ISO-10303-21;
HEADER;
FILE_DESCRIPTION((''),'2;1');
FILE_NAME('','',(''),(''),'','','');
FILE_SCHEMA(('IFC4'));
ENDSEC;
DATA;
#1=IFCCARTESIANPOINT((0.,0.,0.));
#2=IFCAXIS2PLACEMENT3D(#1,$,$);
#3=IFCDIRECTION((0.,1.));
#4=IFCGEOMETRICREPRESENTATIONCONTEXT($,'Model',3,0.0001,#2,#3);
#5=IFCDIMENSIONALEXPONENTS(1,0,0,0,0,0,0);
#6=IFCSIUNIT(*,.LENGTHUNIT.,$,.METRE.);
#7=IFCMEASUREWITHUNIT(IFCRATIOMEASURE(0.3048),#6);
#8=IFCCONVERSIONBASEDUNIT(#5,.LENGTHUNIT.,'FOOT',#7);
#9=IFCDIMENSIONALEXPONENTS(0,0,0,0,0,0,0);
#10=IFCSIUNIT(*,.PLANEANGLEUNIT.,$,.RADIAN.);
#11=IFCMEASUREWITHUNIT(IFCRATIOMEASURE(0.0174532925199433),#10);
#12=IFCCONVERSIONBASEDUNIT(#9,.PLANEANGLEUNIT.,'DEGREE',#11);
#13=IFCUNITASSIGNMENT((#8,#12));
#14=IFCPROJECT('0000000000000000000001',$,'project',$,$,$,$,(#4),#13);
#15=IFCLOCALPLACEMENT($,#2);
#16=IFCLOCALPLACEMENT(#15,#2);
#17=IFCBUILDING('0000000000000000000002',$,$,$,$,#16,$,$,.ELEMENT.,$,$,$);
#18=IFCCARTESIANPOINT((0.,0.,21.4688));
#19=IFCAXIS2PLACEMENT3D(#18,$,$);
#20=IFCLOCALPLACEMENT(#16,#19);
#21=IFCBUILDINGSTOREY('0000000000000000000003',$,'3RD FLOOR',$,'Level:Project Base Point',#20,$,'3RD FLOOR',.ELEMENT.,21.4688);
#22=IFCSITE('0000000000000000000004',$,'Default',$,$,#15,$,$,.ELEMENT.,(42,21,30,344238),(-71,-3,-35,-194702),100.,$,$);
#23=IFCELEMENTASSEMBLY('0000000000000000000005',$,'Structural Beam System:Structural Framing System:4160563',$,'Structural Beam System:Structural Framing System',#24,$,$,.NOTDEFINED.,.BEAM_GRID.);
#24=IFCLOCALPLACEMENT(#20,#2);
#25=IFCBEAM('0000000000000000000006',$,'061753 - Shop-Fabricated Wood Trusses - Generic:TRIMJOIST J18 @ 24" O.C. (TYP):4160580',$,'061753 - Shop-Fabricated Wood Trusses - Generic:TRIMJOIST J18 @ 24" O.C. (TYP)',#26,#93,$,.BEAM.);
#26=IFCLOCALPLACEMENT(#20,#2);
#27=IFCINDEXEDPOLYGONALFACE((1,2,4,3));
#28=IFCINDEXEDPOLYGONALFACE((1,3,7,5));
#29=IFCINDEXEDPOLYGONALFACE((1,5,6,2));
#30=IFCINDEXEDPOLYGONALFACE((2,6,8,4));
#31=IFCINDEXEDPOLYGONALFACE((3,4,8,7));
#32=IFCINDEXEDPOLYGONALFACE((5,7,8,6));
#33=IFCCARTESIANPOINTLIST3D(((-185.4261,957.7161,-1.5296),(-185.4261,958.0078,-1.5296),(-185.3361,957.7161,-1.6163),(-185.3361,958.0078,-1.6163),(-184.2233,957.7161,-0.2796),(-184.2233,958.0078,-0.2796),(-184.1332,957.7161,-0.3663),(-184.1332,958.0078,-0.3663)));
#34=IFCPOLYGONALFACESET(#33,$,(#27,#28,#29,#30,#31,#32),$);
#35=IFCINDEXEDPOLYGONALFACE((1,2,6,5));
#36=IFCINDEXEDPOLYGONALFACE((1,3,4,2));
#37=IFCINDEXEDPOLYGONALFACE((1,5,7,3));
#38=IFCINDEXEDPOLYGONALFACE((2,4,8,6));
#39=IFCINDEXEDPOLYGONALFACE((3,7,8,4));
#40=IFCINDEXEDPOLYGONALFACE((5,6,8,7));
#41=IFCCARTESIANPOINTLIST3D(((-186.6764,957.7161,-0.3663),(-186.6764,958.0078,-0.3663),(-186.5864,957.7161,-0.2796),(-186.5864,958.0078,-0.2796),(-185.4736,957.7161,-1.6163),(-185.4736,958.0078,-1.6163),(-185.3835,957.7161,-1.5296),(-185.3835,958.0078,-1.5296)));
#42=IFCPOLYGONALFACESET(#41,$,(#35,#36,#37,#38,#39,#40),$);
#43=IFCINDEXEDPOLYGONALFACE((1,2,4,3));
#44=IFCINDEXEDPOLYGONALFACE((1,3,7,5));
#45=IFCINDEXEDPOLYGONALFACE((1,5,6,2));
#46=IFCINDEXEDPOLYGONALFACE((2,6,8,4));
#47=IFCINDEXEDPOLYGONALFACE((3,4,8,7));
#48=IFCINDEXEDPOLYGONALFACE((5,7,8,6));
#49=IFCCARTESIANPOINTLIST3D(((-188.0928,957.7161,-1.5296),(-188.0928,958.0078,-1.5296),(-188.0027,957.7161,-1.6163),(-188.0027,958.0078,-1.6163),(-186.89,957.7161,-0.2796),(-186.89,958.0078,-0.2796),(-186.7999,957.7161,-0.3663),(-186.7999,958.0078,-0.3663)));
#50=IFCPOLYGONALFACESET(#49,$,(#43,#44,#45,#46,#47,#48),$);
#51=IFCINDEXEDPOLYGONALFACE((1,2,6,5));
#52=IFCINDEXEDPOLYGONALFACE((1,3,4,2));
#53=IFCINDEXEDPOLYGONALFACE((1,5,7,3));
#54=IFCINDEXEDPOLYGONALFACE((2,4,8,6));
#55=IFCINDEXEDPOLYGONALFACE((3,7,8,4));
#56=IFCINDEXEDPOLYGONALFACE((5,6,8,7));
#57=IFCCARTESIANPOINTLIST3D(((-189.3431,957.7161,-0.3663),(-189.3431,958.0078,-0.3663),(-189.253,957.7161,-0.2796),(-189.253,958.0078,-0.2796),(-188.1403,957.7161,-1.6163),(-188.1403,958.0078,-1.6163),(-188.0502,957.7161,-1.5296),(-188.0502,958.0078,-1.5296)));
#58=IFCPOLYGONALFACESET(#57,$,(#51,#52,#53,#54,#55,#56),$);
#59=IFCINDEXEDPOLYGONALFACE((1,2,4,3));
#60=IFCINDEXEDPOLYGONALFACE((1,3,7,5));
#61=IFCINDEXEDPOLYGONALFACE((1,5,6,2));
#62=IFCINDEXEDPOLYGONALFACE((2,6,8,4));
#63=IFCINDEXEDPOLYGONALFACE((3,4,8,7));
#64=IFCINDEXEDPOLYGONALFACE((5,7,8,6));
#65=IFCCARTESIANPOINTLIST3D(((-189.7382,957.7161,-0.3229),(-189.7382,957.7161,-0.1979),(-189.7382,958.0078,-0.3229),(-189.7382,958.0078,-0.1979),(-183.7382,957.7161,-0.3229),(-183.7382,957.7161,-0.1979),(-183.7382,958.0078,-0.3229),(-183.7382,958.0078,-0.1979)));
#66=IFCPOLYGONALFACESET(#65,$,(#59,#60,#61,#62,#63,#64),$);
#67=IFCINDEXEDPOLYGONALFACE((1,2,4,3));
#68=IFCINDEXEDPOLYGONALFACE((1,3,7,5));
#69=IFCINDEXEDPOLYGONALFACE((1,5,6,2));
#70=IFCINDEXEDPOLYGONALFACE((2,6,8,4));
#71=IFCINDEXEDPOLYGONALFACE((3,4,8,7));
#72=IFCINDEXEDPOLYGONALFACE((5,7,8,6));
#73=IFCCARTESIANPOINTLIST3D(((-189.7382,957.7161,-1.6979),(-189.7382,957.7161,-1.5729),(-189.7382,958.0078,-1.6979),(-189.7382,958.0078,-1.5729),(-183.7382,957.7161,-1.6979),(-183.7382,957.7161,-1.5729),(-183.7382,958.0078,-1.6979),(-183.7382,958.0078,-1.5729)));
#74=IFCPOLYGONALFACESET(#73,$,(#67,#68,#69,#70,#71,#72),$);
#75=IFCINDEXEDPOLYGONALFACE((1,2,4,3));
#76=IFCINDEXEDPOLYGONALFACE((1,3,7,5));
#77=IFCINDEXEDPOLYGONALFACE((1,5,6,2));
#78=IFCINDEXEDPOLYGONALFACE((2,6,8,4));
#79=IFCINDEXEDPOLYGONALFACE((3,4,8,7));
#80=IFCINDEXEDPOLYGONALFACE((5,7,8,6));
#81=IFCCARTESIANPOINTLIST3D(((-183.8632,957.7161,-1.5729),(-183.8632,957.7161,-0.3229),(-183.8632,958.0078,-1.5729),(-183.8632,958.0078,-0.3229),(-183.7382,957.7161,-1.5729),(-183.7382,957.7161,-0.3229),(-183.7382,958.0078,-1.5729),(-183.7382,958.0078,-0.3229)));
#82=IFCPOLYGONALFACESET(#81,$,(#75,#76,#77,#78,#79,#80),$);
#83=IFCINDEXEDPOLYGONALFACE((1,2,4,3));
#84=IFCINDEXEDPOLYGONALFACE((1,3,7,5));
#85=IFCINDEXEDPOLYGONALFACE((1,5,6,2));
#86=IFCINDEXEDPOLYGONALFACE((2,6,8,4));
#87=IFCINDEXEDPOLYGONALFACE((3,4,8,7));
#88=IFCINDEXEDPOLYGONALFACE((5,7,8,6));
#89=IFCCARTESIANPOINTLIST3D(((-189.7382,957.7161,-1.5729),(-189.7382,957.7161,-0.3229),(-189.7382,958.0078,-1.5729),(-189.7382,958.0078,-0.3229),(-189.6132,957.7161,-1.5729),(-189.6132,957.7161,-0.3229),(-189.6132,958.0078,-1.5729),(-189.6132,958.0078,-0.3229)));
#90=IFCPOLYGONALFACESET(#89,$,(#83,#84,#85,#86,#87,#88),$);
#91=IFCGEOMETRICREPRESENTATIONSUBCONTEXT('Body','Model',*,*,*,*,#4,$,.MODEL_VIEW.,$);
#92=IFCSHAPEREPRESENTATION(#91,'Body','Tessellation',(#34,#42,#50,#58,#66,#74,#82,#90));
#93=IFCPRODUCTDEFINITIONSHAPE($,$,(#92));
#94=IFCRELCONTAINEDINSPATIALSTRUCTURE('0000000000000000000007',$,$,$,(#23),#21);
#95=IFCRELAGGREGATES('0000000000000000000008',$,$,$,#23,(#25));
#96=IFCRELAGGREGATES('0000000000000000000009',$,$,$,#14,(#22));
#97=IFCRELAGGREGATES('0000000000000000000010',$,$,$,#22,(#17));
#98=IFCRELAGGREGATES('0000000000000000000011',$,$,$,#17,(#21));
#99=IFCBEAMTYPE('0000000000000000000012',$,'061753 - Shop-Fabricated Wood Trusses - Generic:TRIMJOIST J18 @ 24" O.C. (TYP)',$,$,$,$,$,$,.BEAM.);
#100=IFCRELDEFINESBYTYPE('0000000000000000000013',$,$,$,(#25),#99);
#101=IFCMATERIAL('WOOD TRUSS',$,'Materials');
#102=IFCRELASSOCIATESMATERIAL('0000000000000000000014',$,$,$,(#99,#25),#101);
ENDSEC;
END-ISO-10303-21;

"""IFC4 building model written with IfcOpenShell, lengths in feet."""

from ifc_helpers import new_model, entity, si_unit, converted_unit, direction, frame, frame_2d, origin, origin_2d_with_axis, place, context, subcontext, project, spatial, rectangle, extrude, source, transform, mapped, material, material_profile, profile_set, profile_usage, type_object, type_shapes, element, aggregate, save


model = new_model("IFC4")

# Units and contexts
model_context = context("Model", 3, precision=0.0001, world=origin(), true_north=direction((0.0, 1.0)))
body_context = subcontext(model_context, "Body", "Model", "MODEL_VIEW")
ifc_project = project(units=[converted_unit("LENGTHUNIT", "FOOT", entity("IfcRatioMeasure", 0.3048), si_unit("LENGTHUNIT", "METRE"), dimensions=[1, 0, 0, 0, 0, 0, 0]), converted_unit("PLANEANGLEUNIT", "DEGREE", entity("IfcRatioMeasure", 0.0174532925199433), si_unit("PLANEANGLEUNIT", "RADIAN"), dimensions=[0, 0, 0, 0, 0, 0, 0])], contexts=[model_context])

# Site, building, storey
site_placement = place(None, origin())
site = spatial("IfcSite", under=ifc_project, at=site_placement, Name="Default", CompositionType="ELEMENT", RefLatitude=(42, 21, 30, 344238), RefLongitude=(-71, -3, -35, -194702), RefElevation=100.0)
building_placement = place(site_placement, origin())
building = spatial("IfcBuilding", under=site, at=building_placement, CompositionType="ELEMENT")
storey_placement = place(building_placement, frame((0.0, 0.0, 21.4688)))
storey = spatial("IfcBuildingStorey", under=building, at=storey_placement, Name="3RD FLOOR", ObjectType="Level:Project Base Point", LongName="3RD FLOOR", CompositionType="ELEMENT", Elevation=21.4688)

# Shared definitions
ifc_material_1 = material(Name="WOOD TRUSS", Category="Materials")
ifc_material_profile_1 = material_profile(ifc_material_1, rectangle(XDim=1.7347, YDim=0.125, at=frame_2d((0.0, 0.0), x_axis=(1.0, 0.0))), Name="TRIMJOIST J18 @ 24\" O.C. (TYP)")
ifc_material_profile_2 = material_profile(ifc_material_1, rectangle(XDim=1.7347, YDim=0.125, at=frame_2d((0.0, 0.0), x_axis=(1.0, 0.0))), Name="TRIMJOIST J18 @ 24\" O.C. (TYP)")
ifc_material_profile_3 = material_profile(ifc_material_1, rectangle(XDim=1.7347, YDim=0.125, at=frame_2d((0.0, 0.0), x_axis=(1.0, 0.0))), Name="TRIMJOIST J18 @ 24\" O.C. (TYP)")
ifc_material_profile_4 = material_profile(ifc_material_1, rectangle(XDim=1.7347, YDim=0.125, at=frame_2d((0.0, 0.0), x_axis=(1.0, 0.0))), Name="TRIMJOIST J18 @ 24\" O.C. (TYP)")
ifc_material_profile_5 = material_profile(ifc_material_1, rectangle(XDim=1.7347, YDim=0.125, at=frame_2d((0.0, 0.0), x_axis=(1.0, 0.0))), Name="TRIMJOIST J18 @ 24\" O.C. (TYP)")
ifc_material_profile_6 = material_profile(ifc_material_1, rectangle(XDim=1.7347, YDim=0.125, at=frame_2d((0.0, 0.0), x_axis=(1.0, 0.0))), Name="TRIMJOIST J18 @ 24\" O.C. (TYP)")
ifc_material_profile_7 = material_profile(ifc_material_1, rectangle(XDim=1.7347, YDim=0.125, at=frame_2d((0.0, 0.0), x_axis=(1.0, 0.0))), Name="TRIMJOIST J18 @ 24\" O.C. (TYP)")
ifc_material_profile_8 = material_profile(ifc_material_1, rectangle(XDim=1.7347, YDim=0.125, at=frame_2d((0.0, 0.0), x_axis=(1.0, 0.0))), Name="TRIMJOIST J18 @ 24\" O.C. (TYP)")
ifc_material_profile_9 = material_profile(ifc_material_1, rectangle(XDim=1.7347, YDim=0.125, at=frame_2d((0.0, 0.0), x_axis=(1.0, 0.0))), Name="TRIMJOIST J18 @ 24\" O.C. (TYP)")
ifc_material_profile_10 = material_profile(ifc_material_1, rectangle(XDim=1.7347, YDim=0.125, at=origin_2d_with_axis()), Name="TRIMJOIST J18 @ 24\" O.C. (TYP)")
ifc_material_profile_11 = material_profile(ifc_material_1, rectangle(XDim=0.125, YDim=0.2917, at=origin_2d_with_axis()), Name="TRIMJOIST J18 @ 24\" O.C. (TYP)")
ifc_material_profile_12 = material_profile(ifc_material_1, rectangle(XDim=0.125, YDim=0.2917, at=origin_2d_with_axis()), Name="TRIMJOIST J18 @ 24\" O.C. (TYP)")
ifc_material_profile_13 = material_profile(ifc_material_1, rectangle(XDim=1.25, YDim=0.2917, at=origin_2d_with_axis()), Name="TRIMJOIST J18 @ 24\" O.C. (TYP)")
ifc_material_profile_14 = material_profile(ifc_material_1, rectangle(XDim=1.25, YDim=0.2917, at=origin_2d_with_axis()), Name="TRIMJOIST J18 @ 24\" O.C. (TYP)")
ifc_profile_set_1 = profile_set([ifc_material_profile_1, ifc_material_profile_2, ifc_material_profile_3, ifc_material_profile_4, ifc_material_profile_5, ifc_material_profile_6, ifc_material_profile_7, ifc_material_profile_8, ifc_material_profile_9, ifc_material_profile_10, ifc_material_profile_11, ifc_material_profile_12, ifc_material_profile_13, ifc_material_profile_14], Name="TRIMJOIST J18 @ 24\" O.C. (TYP)")

# Element assembly
assembly_1_placement = place(storey_placement, origin())
assembly_1 = element("IfcElementAssembly", 1, at=assembly_1_placement, inside=storey, Name="Structural Beam System:Structural Framing System:4160563", ObjectType="Structural Beam System:Structural Framing System", AssemblyPlace="NOTDEFINED", PredefinedType="BEAM_GRID")

# Beam
ifc_profile_usage_1 = profile_usage(ifc_profile_set_1, cardinal=8)
beam_type_1 = type_object("IfcBeamType", Name="061753 - Shop-Fabricated Wood Trusses - Generic:TRIMJOIST J18 @ 24\" O.C. (TYP)", PredefinedType="BEAM", material=ifc_profile_set_1)
shared_shape_1 = source(origin(), body_context, "Body", "SweptSolid", [
    extrude(rectangle(XDim=1.7347, YDim=0.125, at=frame_2d((0.0, 0.0), x_axis=(1.0, 0.0))), frame((1.9585, -0.1458, 0.0), z_axis=(0.0, 1.0, 0.0), x_axis=(0.693383, 0.0, 0.720569)), (0.0, 0.0, 1.0), 0.2917),
    extrude(rectangle(XDim=1.7347, YDim=0.125, at=frame_2d((0.0, 0.0), x_axis=(1.0, 0.0))), frame((0.7082, -0.1458, 0.0), z_axis=(0.0, 1.0, 0.0), x_axis=(0.693383, 0.0, -0.720569)), (0.0, 0.0, 1.0), 0.2917),
    extrude(rectangle(XDim=1.7347, YDim=0.125, at=frame_2d((0.0, 0.0), x_axis=(1.0, 0.0))), frame((-0.7082, -0.1458, 0.0), z_axis=(0.0, 1.0, 0.0), x_axis=(0.693383, 0.0, 0.720569)), (0.0, 0.0, 1.0), 0.2917),
    extrude(rectangle(XDim=1.7347, YDim=0.125, at=frame_2d((0.0, 0.0), x_axis=(1.0, 0.0))), frame((-1.9585, -0.1458, 0.0), z_axis=(0.0, 1.0, 0.0), x_axis=(0.693383, 0.0, -0.720569)), (0.0, 0.0, 1.0), 0.2917),
    extrude(rectangle(XDim=0.125, YDim=0.2917, at=origin_2d_with_axis()), frame((-3.0, 0.0, 0.6875), z_axis=(1.0, 0.0, 0.0), x_axis=(0.0, 0.0, -1.0)), (0.0, 0.0, 1.0), 6.0),
    extrude(rectangle(XDim=0.125, YDim=0.2917, at=origin_2d_with_axis()), frame((-3.0, 0.0, -0.6875), z_axis=(1.0, 0.0, 0.0), x_axis=(0.0, 0.0, -1.0)), (0.0, 0.0, 1.0), 6.0),
    extrude(rectangle(XDim=1.25, YDim=0.2917, at=origin_2d_with_axis()), frame((2.875, 0.0, 0.0), z_axis=(1.0, 0.0, 0.0), x_axis=(0.0, 0.0, -1.0)), (0.0, 0.0, 1.0), 0.125),
    extrude(rectangle(XDim=1.25, YDim=0.2917, at=origin_2d_with_axis()), frame((-3.0, 0.0, 0.0), z_axis=(1.0, 0.0, 0.0), x_axis=(0.0, 0.0, -1.0)), (0.0, 0.0, 1.0), 0.125),
])
type_shapes(beam_type_1, [shared_shape_1])
beam_1_placement = place(assembly_1_placement, frame((-186.7382, 957.8619, -0.9479)))
beam_1 = element("IfcBeam", 2, at=beam_1_placement, type_object=beam_type_1, material=ifc_profile_usage_1, Name="061753 - Shop-Fabricated Wood Trusses - Generic:TRIMJOIST J18 @ 24\" O.C. (TYP):4160580", ObjectType="061753 - Shop-Fabricated Wood Trusses - Generic:TRIMJOIST J18 @ 24\" O.C. (TYP)", PredefinedType="BEAM", context=body_context, shape_type="MappedRepresentation", body=[
    mapped(shared_shape_1, transform((0.0, 0.0, 0.0), scale=1.0)),
])
aggregate(assembly_1, [beam_1])

save(model, "model.ifc")
